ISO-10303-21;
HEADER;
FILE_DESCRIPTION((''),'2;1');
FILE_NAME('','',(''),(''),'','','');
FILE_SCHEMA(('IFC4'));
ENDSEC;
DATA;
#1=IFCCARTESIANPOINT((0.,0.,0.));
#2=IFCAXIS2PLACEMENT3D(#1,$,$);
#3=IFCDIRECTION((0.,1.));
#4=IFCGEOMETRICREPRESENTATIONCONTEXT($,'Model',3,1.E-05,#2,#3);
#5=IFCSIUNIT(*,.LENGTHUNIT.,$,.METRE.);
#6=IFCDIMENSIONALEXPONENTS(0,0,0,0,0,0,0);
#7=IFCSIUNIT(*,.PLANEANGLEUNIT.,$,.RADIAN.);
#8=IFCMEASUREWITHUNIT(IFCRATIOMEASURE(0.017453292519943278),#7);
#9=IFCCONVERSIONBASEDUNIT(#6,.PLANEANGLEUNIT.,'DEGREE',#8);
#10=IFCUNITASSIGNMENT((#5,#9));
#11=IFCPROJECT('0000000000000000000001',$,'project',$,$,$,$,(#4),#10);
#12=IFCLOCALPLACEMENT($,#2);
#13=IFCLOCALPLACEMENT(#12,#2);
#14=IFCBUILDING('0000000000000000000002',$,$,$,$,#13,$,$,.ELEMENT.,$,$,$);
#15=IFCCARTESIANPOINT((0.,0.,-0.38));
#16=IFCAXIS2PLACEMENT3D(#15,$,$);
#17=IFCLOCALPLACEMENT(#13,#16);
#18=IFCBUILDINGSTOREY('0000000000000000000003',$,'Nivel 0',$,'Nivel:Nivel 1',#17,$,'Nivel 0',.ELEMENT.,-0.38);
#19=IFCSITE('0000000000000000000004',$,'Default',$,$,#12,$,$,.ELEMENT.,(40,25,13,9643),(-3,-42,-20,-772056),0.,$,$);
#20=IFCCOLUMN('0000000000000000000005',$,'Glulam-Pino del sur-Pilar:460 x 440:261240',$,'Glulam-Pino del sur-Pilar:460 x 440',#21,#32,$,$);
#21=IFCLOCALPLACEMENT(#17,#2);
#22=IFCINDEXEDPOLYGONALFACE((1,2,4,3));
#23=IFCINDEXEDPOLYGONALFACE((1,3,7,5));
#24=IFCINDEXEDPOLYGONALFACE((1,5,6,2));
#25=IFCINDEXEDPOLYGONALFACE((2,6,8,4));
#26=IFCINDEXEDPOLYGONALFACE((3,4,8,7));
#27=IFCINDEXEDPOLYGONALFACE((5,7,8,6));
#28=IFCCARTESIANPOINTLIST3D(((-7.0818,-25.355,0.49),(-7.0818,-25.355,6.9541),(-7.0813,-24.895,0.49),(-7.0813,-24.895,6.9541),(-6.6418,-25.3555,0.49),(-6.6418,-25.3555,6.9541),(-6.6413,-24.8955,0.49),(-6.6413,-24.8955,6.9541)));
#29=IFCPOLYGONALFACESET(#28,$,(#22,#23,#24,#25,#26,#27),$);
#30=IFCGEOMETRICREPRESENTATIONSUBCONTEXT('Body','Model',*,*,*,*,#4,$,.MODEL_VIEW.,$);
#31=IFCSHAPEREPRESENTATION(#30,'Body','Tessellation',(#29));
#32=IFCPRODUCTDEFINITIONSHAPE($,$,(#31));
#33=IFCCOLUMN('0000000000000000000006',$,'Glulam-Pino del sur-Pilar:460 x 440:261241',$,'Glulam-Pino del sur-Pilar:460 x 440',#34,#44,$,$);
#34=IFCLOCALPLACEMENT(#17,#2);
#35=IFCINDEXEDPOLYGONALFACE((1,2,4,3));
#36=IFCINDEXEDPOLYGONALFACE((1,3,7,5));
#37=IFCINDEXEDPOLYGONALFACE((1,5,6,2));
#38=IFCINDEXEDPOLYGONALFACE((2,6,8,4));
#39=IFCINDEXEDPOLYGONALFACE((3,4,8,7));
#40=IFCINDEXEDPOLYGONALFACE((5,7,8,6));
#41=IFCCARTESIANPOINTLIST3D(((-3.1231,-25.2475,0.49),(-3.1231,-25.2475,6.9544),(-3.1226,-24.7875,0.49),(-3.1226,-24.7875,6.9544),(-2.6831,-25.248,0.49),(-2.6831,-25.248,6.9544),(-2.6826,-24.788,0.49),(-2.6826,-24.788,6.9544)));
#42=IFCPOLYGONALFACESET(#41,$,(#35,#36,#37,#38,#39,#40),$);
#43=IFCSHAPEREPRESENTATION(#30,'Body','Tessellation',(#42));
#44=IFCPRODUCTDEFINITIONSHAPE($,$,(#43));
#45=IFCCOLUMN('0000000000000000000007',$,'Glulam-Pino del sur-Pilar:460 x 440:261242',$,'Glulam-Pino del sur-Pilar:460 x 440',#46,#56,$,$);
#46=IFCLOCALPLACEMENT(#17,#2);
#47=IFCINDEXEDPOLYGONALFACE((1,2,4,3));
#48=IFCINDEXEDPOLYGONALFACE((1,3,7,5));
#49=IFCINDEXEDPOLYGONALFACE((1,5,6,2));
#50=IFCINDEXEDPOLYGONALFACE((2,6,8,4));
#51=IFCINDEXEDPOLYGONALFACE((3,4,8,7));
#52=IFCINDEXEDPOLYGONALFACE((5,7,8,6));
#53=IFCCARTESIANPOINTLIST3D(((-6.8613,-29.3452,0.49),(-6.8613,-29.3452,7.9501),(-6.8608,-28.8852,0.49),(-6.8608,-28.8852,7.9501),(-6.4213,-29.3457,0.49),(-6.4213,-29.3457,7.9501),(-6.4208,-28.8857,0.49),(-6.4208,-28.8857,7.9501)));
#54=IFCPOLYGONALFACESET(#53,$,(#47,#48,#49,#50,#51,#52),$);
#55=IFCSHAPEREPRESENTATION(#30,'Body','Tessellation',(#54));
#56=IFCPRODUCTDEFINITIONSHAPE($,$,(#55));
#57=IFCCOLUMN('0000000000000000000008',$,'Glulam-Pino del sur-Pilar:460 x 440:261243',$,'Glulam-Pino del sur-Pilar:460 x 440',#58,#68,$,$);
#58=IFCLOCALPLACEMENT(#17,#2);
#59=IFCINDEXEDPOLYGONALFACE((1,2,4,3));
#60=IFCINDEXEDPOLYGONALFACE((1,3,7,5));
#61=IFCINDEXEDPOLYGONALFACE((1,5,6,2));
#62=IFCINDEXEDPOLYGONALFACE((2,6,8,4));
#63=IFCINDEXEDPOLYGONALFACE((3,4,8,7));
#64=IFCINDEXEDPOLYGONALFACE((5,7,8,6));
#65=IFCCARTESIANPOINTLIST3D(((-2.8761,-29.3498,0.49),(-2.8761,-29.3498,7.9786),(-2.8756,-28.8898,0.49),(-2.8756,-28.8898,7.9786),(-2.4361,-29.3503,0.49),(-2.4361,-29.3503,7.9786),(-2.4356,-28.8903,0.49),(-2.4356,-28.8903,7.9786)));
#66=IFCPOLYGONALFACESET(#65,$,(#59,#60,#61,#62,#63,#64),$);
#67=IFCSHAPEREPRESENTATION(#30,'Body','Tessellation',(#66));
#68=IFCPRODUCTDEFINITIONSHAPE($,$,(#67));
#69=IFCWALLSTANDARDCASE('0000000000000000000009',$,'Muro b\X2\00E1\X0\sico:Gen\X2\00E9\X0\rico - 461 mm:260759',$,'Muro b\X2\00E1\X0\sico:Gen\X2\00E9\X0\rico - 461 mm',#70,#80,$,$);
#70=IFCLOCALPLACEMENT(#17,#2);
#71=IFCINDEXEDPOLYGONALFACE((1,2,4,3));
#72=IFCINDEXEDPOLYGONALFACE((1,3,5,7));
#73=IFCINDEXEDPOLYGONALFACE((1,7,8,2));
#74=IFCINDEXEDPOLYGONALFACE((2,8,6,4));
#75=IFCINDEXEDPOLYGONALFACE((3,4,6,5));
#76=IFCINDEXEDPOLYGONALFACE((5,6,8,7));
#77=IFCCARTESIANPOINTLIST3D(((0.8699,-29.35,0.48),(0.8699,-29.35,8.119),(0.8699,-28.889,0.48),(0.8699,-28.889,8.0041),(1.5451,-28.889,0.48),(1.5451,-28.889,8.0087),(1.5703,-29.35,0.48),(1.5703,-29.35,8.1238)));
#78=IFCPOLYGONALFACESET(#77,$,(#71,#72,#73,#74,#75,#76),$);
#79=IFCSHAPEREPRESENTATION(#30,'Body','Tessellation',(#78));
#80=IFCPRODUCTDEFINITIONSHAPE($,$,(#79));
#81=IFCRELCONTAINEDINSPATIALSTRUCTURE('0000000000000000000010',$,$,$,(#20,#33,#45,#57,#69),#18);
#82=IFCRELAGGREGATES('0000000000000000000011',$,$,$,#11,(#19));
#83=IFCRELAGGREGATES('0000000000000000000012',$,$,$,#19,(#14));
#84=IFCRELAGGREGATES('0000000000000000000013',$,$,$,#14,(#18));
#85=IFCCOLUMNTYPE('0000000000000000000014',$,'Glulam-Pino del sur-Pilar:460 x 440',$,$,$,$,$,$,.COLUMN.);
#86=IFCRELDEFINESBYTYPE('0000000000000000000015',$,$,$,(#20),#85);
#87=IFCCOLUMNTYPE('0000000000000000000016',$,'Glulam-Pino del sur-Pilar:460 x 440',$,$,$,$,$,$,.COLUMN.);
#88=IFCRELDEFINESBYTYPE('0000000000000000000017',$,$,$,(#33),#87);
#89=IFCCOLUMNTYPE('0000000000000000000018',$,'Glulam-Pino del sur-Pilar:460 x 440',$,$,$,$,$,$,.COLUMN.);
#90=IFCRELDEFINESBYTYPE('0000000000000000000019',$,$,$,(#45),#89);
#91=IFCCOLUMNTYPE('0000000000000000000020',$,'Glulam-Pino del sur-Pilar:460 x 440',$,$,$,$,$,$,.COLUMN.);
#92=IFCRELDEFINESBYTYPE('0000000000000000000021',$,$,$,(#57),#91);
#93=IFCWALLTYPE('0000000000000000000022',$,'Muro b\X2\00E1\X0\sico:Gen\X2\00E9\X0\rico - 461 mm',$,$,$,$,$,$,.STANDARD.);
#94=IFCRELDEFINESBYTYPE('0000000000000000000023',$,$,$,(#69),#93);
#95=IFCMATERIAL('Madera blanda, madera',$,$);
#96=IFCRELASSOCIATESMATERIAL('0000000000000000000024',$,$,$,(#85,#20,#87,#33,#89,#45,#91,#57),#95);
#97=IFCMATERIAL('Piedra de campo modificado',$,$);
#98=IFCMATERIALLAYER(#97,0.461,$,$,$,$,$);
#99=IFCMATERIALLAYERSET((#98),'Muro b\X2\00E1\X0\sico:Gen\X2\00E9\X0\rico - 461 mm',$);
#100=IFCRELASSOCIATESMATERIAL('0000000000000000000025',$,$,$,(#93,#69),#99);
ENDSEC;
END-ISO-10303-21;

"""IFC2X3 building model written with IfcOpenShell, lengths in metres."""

from ifc_helpers import new_model, entity, si_unit, converted_unit, direction, frame, origin, origin_2d_with_axis, place, context, subcontext, project, spatial, polyline, rectangle, outline, extrude, clip, bounded_halfspace, source, transform, mapped, material, layer, layer_set, layer_usage, type_object, type_shapes, element, save


model = new_model("IFC2X3")

# Units and contexts
model_context = context("Model", 3, precision=1e-05, world=origin(), true_north=direction((0.0, 1.0)))
body_context = subcontext(model_context, "Body", "Model", "MODEL_VIEW")
ifc_project = project(units=[si_unit("LENGTHUNIT", "METRE"), converted_unit("PLANEANGLEUNIT", "DEGREE", entity("IfcRatioMeasure", 0.017453292519943278), si_unit("PLANEANGLEUNIT", "RADIAN"), dimensions=[0, 0, 0, 0, 0, 0, 0])], contexts=[model_context])

# Site, building, storey
site_placement = place(None, origin())
site = spatial("IfcSite", under=ifc_project, at=site_placement, Name="Default", CompositionType="ELEMENT", RefLatitude=(40, 25, 13, 9643), RefLongitude=(-3, -42, -20, -772056), RefElevation=0.0)
building_placement = place(site_placement, origin())
building = spatial("IfcBuilding", under=site, at=building_placement, CompositionType="ELEMENT")
storey_placement = place(building_placement, frame((0.0, 0.0, -0.38)))
storey = spatial("IfcBuildingStorey", under=building, at=storey_placement, Name="Nivel 0", ObjectType="Nivel:Nivel 1", LongName="Nivel 0", CompositionType="ELEMENT", Elevation=-0.38)

# Columns
ifc_material_1 = material(Name="Madera blanda, madera")
column_type_1 = type_object("IfcColumnType", Name="Glulam-Pino del sur-Pilar:460 x 440", PredefinedType="COLUMN", material=ifc_material_1)
shared_shape_1 = source(origin(), body_context, "Body", "SweptSolid", [
    extrude(rectangle(XDim=0.46, YDim=0.44, at=origin_2d_with_axis()), frame((-6.8615, -25.1252, 0.11), z_axis=(0.0, 0.0, 1.0), x_axis=(0.001152, 0.999999, 0.0)), (0.0, 0.0, 1.0), 6.4641),
])
type_shapes(column_type_1, [shared_shape_1])
column_1_placement = place(storey_placement, frame((0.0, 0.0, 0.38)))
element("IfcColumn", 1, at=column_1_placement, inside=storey, type_object=column_type_1, material=ifc_material_1, Name="Glulam-Pino del sur-Pilar:460 x 440:261240", ObjectType="Glulam-Pino del sur-Pilar:460 x 440", context=body_context, shape_type="MappedRepresentation", body=[
    mapped(shared_shape_1, transform((0.0, 0.0, 0.0), scale=1.0)),
])
column_type_2 = type_object("IfcColumnType", Name="Glulam-Pino del sur-Pilar:460 x 440", PredefinedType="COLUMN", material=ifc_material_1)
shared_shape_2 = source(origin(), body_context, "Body", "SweptSolid", [
    extrude(rectangle(XDim=0.46, YDim=0.44, at=origin_2d_with_axis()), frame((-2.9029, -25.0177, 0.11), z_axis=(0.0, 0.0, 1.0), x_axis=(0.001152, 0.999999, 0.0)), (0.0, 0.0, 1.0), 6.4644),
])
type_shapes(column_type_2, [shared_shape_2])
column_2_placement = place(storey_placement, frame((0.0, 0.0, 0.38)))
element("IfcColumn", 2, at=column_2_placement, inside=storey, type_object=column_type_2, material=ifc_material_1, Name="Glulam-Pino del sur-Pilar:460 x 440:261241", ObjectType="Glulam-Pino del sur-Pilar:460 x 440", context=body_context, shape_type="MappedRepresentation", body=[
    mapped(shared_shape_2, transform((0.0, 0.0, 0.0), scale=1.0)),
])
column_type_3 = type_object("IfcColumnType", Name="Glulam-Pino del sur-Pilar:460 x 440", PredefinedType="COLUMN", material=ifc_material_1)
shared_shape_3 = source(origin(), body_context, "Body", "SweptSolid", [
    extrude(rectangle(XDim=0.46, YDim=0.44, at=origin_2d_with_axis()), frame((-6.6411, -29.1155, 0.11), z_axis=(0.0, 0.0, 1.0), x_axis=(0.001152, 0.999999, 0.0)), (0.0, 0.0, 1.0), 7.4601),
])
type_shapes(column_type_3, [shared_shape_3])
column_3_placement = place(storey_placement, frame((0.0, 0.0, 0.38)))
element("IfcColumn", 3, at=column_3_placement, inside=storey, type_object=column_type_3, material=ifc_material_1, Name="Glulam-Pino del sur-Pilar:460 x 440:261242", ObjectType="Glulam-Pino del sur-Pilar:460 x 440", context=body_context, shape_type="MappedRepresentation", body=[
    mapped(shared_shape_3, transform((0.0, 0.0, 0.0), scale=1.0)),
])
column_type_4 = type_object("IfcColumnType", Name="Glulam-Pino del sur-Pilar:460 x 440", PredefinedType="COLUMN", material=ifc_material_1)
shared_shape_4 = source(origin(), body_context, "Body", "SweptSolid", [
    extrude(rectangle(XDim=0.46, YDim=0.44, at=origin_2d_with_axis()), frame((-2.6558, -29.12, 0.11), z_axis=(0.0, 0.0, 1.0), x_axis=(0.001152, 0.999999, 0.0)), (0.0, 0.0, 1.0), 7.4886),
])
type_shapes(column_type_4, [shared_shape_4])
column_4_placement = place(storey_placement, frame((0.0, 0.0, 0.38)))
element("IfcColumn", 4, at=column_4_placement, inside=storey, type_object=column_type_4, material=ifc_material_1, Name="Glulam-Pino del sur-Pilar:460 x 440:261243", ObjectType="Glulam-Pino del sur-Pilar:460 x 440", context=body_context, shape_type="MappedRepresentation", body=[
    mapped(shared_shape_4, transform((0.0, 0.0, 0.0), scale=1.0)),
])

# Wall
ifc_material_2 = material(Name="Piedra de campo modificado")
ifc_layer_1 = layer(ifc_material_2, 0.461)
ifc_layer_set_1 = layer_set([ifc_layer_1], Name="Muro básico:Genérico - 461 mm")
ifc_layer_usage_1 = layer_usage(ifc_layer_set_1, "AXIS2", "NEGATIVE", 0.2305)
wall_type = type_object("IfcWallType", Name="Muro básico:Genérico - 461 mm", PredefinedType="STANDARD", material=ifc_layer_set_1)
wall_placement = place(storey_placement, frame((1.5703, -29.1195, 0.48), z_axis=(0.0, 0.0, 1.0), x_axis=(-1.0, 0.0, 0.0)))
element("IfcWallStandardCase", 5, at=wall_placement, inside=storey, type_object=wall_type, material=ifc_layer_usage_1, Name="Muro básico:Genérico - 461 mm:260759", ObjectType="Muro básico:Genérico - 461 mm", context=body_context, shape_type="Clipping", body=[
    clip(extrude(outline(polyline([(0.7004, -0.2305), (0.7004, 0.2305), (0.0, 0.2305), (0.0252, -0.2305), (0.4459, -0.2305), (0.7004, -0.2305)])), origin(), (0.0, 0.0, 1.0), 7.6438), bounded_halfspace(frame((0.0252, -0.2305, 7.5287), z_axis=(0.006656, -0.24183, 0.970296), x_axis=(0.999621, 0.027514, 0.0)), False, frame((0.0252, -0.2305, 7.5287)), polyline([(0.0, 0.0), (0.4206, 0.0), (0.6752, 0.0), (0.6752, 0.461), (-0.0252, 0.461), (0.0, 0.0)]))),
])

save(model, "model.ifc")
